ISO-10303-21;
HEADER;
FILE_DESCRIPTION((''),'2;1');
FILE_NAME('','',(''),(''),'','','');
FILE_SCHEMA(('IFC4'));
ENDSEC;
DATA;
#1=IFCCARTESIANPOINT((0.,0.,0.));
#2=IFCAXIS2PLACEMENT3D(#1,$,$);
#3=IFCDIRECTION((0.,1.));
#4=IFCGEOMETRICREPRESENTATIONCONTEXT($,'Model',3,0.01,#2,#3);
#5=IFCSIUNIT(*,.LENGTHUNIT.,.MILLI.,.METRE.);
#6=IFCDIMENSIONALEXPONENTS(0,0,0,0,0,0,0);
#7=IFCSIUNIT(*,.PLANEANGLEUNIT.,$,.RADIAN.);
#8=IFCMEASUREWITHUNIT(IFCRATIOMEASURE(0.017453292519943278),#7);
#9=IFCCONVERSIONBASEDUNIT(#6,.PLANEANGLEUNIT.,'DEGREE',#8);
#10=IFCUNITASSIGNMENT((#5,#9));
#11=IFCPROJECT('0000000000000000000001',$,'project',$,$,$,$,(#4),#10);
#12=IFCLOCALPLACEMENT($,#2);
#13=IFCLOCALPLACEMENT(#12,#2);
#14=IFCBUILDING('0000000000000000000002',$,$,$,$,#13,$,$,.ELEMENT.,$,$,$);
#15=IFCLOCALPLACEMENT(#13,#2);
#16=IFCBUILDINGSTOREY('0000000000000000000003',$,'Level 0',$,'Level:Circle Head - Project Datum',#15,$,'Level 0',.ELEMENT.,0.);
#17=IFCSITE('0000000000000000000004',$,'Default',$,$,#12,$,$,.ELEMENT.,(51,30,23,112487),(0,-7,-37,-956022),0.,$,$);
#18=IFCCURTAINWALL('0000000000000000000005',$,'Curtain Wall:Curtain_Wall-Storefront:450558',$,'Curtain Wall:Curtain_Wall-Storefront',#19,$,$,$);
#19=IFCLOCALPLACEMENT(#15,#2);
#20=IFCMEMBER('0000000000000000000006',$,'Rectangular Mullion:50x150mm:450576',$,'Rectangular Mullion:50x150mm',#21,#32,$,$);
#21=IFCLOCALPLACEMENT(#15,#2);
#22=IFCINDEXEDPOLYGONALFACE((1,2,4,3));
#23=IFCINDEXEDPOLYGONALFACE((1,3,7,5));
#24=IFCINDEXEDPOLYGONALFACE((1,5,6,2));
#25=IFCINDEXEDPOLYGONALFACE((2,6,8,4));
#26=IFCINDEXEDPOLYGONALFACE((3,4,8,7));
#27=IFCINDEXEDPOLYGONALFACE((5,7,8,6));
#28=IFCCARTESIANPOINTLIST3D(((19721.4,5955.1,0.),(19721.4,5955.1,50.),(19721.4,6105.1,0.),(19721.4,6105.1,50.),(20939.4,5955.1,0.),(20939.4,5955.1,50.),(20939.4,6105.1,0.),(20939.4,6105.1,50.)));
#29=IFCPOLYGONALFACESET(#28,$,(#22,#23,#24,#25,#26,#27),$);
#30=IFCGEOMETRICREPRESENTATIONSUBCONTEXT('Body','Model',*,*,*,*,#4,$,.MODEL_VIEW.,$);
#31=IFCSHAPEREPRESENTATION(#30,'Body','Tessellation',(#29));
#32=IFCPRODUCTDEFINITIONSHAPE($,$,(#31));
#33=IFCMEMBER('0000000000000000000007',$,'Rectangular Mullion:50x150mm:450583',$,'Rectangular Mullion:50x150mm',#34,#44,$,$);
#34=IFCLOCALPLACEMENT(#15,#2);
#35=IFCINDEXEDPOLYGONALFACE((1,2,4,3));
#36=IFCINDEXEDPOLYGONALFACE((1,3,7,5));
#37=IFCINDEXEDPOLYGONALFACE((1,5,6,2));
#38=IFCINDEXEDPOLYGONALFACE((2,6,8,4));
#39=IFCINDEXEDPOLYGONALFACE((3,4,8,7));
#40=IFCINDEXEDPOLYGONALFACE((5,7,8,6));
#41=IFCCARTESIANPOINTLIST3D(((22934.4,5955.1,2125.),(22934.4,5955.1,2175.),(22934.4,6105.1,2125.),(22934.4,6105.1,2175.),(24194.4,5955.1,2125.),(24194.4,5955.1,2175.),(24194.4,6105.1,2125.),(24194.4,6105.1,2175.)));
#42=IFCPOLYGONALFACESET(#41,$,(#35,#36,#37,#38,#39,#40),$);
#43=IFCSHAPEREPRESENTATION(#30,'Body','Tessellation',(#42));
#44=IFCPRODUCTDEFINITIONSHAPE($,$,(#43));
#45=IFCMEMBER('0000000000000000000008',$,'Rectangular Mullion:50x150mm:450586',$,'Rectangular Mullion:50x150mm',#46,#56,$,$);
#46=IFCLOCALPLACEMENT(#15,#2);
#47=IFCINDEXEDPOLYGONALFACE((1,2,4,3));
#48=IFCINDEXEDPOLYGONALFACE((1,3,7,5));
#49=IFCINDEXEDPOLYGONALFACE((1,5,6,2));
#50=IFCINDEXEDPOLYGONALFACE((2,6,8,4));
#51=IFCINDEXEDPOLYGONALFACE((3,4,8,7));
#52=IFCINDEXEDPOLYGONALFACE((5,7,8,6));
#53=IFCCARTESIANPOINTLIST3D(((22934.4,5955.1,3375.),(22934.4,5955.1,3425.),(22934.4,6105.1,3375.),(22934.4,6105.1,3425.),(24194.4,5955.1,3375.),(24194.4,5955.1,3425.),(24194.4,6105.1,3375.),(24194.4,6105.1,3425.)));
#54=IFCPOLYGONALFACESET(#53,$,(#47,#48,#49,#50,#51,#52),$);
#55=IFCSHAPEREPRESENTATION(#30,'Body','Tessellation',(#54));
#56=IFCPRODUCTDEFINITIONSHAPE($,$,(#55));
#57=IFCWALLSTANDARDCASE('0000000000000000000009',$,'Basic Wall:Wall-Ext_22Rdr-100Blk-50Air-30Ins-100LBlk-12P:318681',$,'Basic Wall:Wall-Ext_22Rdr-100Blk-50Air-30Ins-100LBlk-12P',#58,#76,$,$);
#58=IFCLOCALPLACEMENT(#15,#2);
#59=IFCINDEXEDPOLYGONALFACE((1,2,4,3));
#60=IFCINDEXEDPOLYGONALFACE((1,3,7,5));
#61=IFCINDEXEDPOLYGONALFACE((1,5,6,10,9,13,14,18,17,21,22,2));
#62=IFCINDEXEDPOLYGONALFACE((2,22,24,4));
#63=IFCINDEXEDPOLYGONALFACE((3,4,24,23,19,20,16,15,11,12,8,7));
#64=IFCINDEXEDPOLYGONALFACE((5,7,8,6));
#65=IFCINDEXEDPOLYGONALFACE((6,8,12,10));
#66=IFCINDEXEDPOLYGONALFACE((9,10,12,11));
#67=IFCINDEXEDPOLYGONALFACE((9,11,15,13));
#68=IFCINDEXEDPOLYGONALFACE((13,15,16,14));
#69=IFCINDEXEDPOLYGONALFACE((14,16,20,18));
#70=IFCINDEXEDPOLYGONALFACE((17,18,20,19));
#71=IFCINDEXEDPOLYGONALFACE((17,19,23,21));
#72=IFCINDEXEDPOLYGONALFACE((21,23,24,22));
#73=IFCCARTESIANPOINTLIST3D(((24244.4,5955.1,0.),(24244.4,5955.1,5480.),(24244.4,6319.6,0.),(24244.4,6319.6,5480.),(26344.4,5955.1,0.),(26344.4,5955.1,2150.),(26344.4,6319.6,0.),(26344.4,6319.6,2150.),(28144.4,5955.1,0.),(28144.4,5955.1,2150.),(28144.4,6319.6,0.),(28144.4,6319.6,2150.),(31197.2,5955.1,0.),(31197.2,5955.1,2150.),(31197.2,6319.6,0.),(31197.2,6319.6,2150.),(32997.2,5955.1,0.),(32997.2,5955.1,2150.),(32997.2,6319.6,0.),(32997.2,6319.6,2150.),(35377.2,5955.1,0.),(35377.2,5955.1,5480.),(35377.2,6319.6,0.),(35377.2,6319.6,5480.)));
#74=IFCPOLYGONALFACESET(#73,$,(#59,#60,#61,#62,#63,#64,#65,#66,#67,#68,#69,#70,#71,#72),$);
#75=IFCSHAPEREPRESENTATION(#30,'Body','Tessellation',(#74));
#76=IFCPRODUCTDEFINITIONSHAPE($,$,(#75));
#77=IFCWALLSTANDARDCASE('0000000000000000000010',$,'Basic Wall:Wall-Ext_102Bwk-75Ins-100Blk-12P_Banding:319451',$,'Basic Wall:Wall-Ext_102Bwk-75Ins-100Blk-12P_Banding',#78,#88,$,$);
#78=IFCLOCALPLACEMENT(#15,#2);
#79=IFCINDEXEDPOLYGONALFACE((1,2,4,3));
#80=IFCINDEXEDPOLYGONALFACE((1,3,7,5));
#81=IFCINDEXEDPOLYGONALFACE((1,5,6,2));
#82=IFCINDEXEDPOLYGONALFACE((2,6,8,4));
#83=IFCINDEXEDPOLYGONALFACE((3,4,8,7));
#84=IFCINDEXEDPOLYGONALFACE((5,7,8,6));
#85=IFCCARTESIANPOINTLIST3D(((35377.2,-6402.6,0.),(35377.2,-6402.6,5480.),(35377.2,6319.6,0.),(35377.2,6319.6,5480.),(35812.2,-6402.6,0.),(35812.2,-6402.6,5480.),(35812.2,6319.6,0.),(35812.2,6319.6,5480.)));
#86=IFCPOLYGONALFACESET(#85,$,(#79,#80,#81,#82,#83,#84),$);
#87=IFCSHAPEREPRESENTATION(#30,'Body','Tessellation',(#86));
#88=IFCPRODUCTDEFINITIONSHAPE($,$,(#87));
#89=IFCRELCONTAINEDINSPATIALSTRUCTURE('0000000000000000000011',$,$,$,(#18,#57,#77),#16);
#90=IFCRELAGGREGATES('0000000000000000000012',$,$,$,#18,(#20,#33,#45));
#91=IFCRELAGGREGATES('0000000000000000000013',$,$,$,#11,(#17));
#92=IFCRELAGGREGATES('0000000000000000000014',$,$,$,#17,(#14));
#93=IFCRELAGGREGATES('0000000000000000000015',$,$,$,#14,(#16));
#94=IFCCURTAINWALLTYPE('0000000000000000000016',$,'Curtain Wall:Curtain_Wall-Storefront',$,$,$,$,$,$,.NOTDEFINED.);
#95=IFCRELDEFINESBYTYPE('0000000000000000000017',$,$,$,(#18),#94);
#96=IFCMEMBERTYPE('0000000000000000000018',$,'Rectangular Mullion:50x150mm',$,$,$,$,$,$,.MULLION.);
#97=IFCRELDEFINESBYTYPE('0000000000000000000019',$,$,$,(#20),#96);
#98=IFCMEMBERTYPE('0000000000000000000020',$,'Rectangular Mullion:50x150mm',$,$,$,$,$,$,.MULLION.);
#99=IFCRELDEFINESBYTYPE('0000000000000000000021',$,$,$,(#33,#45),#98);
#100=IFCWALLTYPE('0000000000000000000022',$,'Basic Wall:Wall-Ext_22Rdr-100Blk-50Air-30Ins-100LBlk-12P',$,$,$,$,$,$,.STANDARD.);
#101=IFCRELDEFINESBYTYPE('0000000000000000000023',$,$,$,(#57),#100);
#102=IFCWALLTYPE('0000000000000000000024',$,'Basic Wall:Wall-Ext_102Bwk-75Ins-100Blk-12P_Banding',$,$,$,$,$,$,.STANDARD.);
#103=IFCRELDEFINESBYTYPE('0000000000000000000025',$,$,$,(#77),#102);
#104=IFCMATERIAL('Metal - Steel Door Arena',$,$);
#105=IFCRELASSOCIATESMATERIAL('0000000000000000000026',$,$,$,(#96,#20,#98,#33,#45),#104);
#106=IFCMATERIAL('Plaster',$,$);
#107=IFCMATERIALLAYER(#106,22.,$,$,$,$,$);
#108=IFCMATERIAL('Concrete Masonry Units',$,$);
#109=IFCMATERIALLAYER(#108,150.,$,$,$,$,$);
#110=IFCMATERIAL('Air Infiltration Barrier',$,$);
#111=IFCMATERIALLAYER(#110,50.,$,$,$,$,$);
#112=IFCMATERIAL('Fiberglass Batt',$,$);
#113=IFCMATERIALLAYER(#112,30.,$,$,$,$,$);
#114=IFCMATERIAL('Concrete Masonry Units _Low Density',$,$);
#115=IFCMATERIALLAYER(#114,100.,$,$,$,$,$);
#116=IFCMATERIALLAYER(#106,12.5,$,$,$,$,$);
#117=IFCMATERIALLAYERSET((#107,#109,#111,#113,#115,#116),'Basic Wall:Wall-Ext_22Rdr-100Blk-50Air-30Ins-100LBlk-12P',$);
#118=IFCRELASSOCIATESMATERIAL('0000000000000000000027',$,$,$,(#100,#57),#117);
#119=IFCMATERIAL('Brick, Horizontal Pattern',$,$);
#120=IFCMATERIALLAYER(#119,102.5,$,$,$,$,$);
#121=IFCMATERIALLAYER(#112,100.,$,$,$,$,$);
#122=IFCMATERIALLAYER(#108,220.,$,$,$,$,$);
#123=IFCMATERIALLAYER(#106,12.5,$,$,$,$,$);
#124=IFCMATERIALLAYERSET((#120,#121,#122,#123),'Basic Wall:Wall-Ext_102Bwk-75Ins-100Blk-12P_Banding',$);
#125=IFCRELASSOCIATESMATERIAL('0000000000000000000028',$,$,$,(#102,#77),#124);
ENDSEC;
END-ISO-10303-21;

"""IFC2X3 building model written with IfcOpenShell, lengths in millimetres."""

from ifc_helpers import new_model, entity, si_unit, converted_unit, direction, frame, frame_2d, origin, origin_2d_with_axis, place, context, subcontext, project, spatial, rectangle, extrude, source, transform, mapped, material, layer, layer_set, layer_usage, type_object, type_shapes, element, aggregate, save


model = new_model("IFC2X3")

# Units and contexts
model_context = context("Model", 3, precision=0.01, world=origin(), true_north=direction((0.0, 1.0)))
body_context = subcontext(model_context, "Body", "Model", "MODEL_VIEW")
ifc_project = project(units=[si_unit("LENGTHUNIT", "METRE", prefix="MILLI"), converted_unit("PLANEANGLEUNIT", "DEGREE", entity("IfcRatioMeasure", 0.017453292519943278), si_unit("PLANEANGLEUNIT", "RADIAN"), dimensions=[0, 0, 0, 0, 0, 0, 0])], contexts=[model_context])

# Site, building, storey
site_placement = place(None, origin())
site = spatial("IfcSite", under=ifc_project, at=site_placement, Name="Default", CompositionType="ELEMENT", RefLatitude=(51, 30, 23, 112487), RefLongitude=(0, -7, -37, -956022), RefElevation=0.0)
building_placement = place(site_placement, origin())
building = spatial("IfcBuilding", under=site, at=building_placement, CompositionType="ELEMENT")
storey_placement = place(building_placement, origin())
storey = spatial("IfcBuildingStorey", under=building, at=storey_placement, Name="Level 0", ObjectType="Level:Circle Head - Project Datum", LongName="Level 0", CompositionType="ELEMENT", Elevation=0.0)

# Curtain wall, members
curtain_wall_type = type_object("IfcCurtainWallType", Name="Curtain Wall:Curtain_Wall-Storefront", PredefinedType="NOTDEFINED")
curtain_wall_placement = place(storey_placement, origin())
curtain_wall = element("IfcCurtainWall", 1, at=curtain_wall_placement, inside=storey, type_object=curtain_wall_type, Name="Curtain Wall:Curtain_Wall-Storefront:450558", ObjectType="Curtain Wall:Curtain_Wall-Storefront")
ifc_material_1 = material(Name="Metal - Steel Door Arena")
member_type_1 = type_object("IfcMemberType", Name="Rectangular Mullion:50x150mm", PredefinedType="MULLION", material=ifc_material_1)
shared_shape_1 = source(origin(), body_context, "Body", "SweptSolid", [
    extrude(rectangle(XDim=150.0, YDim=50.0, at=origin_2d_with_axis()), frame((-25.0, 0.0, -1218.0), z_axis=(0.0, 0.0, 1.0), x_axis=(0.0, -1.0, 0.0)), (0.0, 0.0, 1.0), 1218.0),
])
type_shapes(member_type_1, [shared_shape_1])
member_1_placement = place(curtain_wall_placement, frame((20939.4, 6030.1, 0.0), z_axis=(1.0, 0.0, 0.0), x_axis=(0.0, 0.0, -1.0)))
member_1 = element("IfcMember", 2, at=member_1_placement, type_object=member_type_1, material=ifc_material_1, Name="Rectangular Mullion:50x150mm:450576", ObjectType="Rectangular Mullion:50x150mm", context=body_context, shape_type="MappedRepresentation", body=[
    mapped(shared_shape_1, transform((0.0, 0.0, 0.0), scale=1.0)),
])
member_type_2 = type_object("IfcMemberType", Name="Rectangular Mullion:50x150mm", PredefinedType="MULLION", material=ifc_material_1)
shared_shape_2 = source(origin(), body_context, "Body", "SweptSolid", [
    extrude(rectangle(XDim=150.0, YDim=50.0, at=origin_2d_with_axis()), frame((0.0, 0.0, -1260.0), z_axis=(0.0, 0.0, 1.0), x_axis=(0.0, -1.0, 0.0)), (0.0, 0.0, 1.0), 1260.0),
])
type_shapes(member_type_2, [shared_shape_2])
member_2_placement = place(curtain_wall_placement, frame((22934.4, 6030.1, 2150.0), z_axis=(-1.0, 0.0, 0.0), x_axis=(0.0, 0.0, 1.0)))
member_2 = element("IfcMember", 3, at=member_2_placement, type_object=member_type_2, material=ifc_material_1, Name="Rectangular Mullion:50x150mm:450583", ObjectType="Rectangular Mullion:50x150mm", context=body_context, shape_type="MappedRepresentation", body=[
    mapped(shared_shape_2, transform((0.0, 0.0, 0.0), scale=1.0)),
])
member_3_placement = place(curtain_wall_placement, frame((22934.4, 6030.1, 3400.0), z_axis=(-1.0, 0.0, 0.0), x_axis=(0.0, 0.0, 1.0)))
member_3 = element("IfcMember", 4, at=member_3_placement, type_object=member_type_2, material=ifc_material_1, Name="Rectangular Mullion:50x150mm:450586", ObjectType="Rectangular Mullion:50x150mm", context=body_context, shape_type="MappedRepresentation", body=[
    mapped(shared_shape_2, transform((0.0, 0.0, 0.0), scale=1.0)),
])
aggregate(curtain_wall, [member_1, member_2, member_3])

# Wall, openings
ifc_material_2 = material(Name="Plaster")
ifc_layer_1 = layer(ifc_material_2, 22.0)
ifc_material_3 = material(Name="Concrete Masonry Units")
ifc_layer_2 = layer(ifc_material_3, 150.0)
ifc_material_4 = material(Name="Air Infiltration Barrier")
ifc_layer_3 = layer(ifc_material_4, 50.0)
ifc_material_5 = material(Name="Fiberglass Batt")
ifc_layer_4 = layer(ifc_material_5, 30.0)
ifc_material_6 = material(Name="Concrete Masonry Units _Low Density")
ifc_layer_5 = layer(ifc_material_6, 100.0)
ifc_layer_6 = layer(ifc_material_2, 12.5)
ifc_layer_set_1 = layer_set([ifc_layer_1, ifc_layer_2, ifc_layer_3, ifc_layer_4, ifc_layer_5, ifc_layer_6], Name="Basic Wall:Wall-Ext_22Rdr-100Blk-50Air-30Ins-100LBlk-12P")
ifc_layer_usage_1 = layer_usage(ifc_layer_set_1, "AXIS2", "NEGATIVE", 182.3)
wall_type_1 = type_object("IfcWallType", Name="Basic Wall:Wall-Ext_22Rdr-100Blk-50Air-30Ins-100LBlk-12P", PredefinedType="STANDARD", material=ifc_layer_set_1)
wall_1_placement = place(storey_placement, frame((35377.2, 6137.4, 0.0), z_axis=(0.0, 0.0, 1.0), x_axis=(-1.0, 0.0, 0.0)))
wall_1 = element("IfcWallStandardCase", 5, at=wall_1_placement, inside=storey, type_object=wall_type_1, material=ifc_layer_usage_1, Name="Basic Wall:Wall-Ext_22Rdr-100Blk-50Air-30Ins-100LBlk-12P:318681", ObjectType="Basic Wall:Wall-Ext_22Rdr-100Blk-50Air-30Ins-100LBlk-12P", context=body_context, shape_type="SweptSolid", body=[
    extrude(rectangle(XDim=11132.8, YDim=364.5, at=frame_2d((5566.4, 0.0), x_axis=(1.0, 0.0))), origin(), (0.0, 0.0, 1.0), 5480.0),
])
opening_1_placement = place(wall_1_placement, frame((9032.7, 182.2, 0.0)))
element("IfcOpeningElement", 6, at=opening_1_placement, cuts=wall_1, ObjectType="Opening", context=body_context, shape_type="SweptSolid", body=[
    extrude(rectangle(XDim=2150.0, YDim=1800.0, at=frame_2d((1075.0, 900.0), x_axis=(1.0, 0.0))), frame((0.0, 0.0, 0.0), z_axis=(0.0, -1.0, 0.0), x_axis=(0.0, 0.0, 1.0)), (0.0, 0.0, 1.0), 364.5),
])
opening_2_placement = place(wall_1_placement, frame((4180.0, 182.2, 0.0)))
element("IfcOpeningElement", 7, at=opening_2_placement, cuts=wall_1, ObjectType="Opening", context=body_context, shape_type="SweptSolid", body=[
    extrude(rectangle(XDim=2150.0, YDim=1800.0, at=frame_2d((1075.0, 900.0), x_axis=(1.0, 0.0))), frame((0.0, 0.0, 0.0), z_axis=(0.0, -1.0, 0.0), x_axis=(0.0, 0.0, 1.0)), (0.0, 0.0, 1.0), 364.5),
])

# Wall
ifc_material_7 = material(Name="Brick, Horizontal Pattern")
ifc_layer_7 = layer(ifc_material_7, 102.5)
ifc_layer_8 = layer(ifc_material_5, 100.0)
ifc_layer_9 = layer(ifc_material_3, 220.0)
ifc_layer_10 = layer(ifc_material_2, 12.5)
ifc_layer_set_2 = layer_set([ifc_layer_7, ifc_layer_8, ifc_layer_9, ifc_layer_10], Name="Basic Wall:Wall-Ext_102Bwk-75Ins-100Blk-12P_Banding")
ifc_layer_usage_2 = layer_usage(ifc_layer_set_2, "AXIS2", "NEGATIVE", 217.5)
wall_type_2 = type_object("IfcWallType", Name="Basic Wall:Wall-Ext_102Bwk-75Ins-100Blk-12P_Banding", PredefinedType="STANDARD", material=ifc_layer_set_2)
wall_2_placement = place(storey_placement, frame((35594.7, 6319.6, 0.0), z_axis=(0.0, 0.0, 1.0), x_axis=(0.0, -1.0, 0.0)))
element("IfcWallStandardCase", 8, at=wall_2_placement, inside=storey, type_object=wall_type_2, material=ifc_layer_usage_2, Name="Basic Wall:Wall-Ext_102Bwk-75Ins-100Blk-12P_Banding:319451", ObjectType="Basic Wall:Wall-Ext_102Bwk-75Ins-100Blk-12P_Banding", context=body_context, shape_type="SweptSolid", body=[
    extrude(rectangle(XDim=12722.3, YDim=435.0, at=frame_2d((6361.1, 0.0), x_axis=(-1.0, 0.0))), origin(), (0.0, 0.0, 1.0), 5480.0),
])

save(model, "model.ifc")
